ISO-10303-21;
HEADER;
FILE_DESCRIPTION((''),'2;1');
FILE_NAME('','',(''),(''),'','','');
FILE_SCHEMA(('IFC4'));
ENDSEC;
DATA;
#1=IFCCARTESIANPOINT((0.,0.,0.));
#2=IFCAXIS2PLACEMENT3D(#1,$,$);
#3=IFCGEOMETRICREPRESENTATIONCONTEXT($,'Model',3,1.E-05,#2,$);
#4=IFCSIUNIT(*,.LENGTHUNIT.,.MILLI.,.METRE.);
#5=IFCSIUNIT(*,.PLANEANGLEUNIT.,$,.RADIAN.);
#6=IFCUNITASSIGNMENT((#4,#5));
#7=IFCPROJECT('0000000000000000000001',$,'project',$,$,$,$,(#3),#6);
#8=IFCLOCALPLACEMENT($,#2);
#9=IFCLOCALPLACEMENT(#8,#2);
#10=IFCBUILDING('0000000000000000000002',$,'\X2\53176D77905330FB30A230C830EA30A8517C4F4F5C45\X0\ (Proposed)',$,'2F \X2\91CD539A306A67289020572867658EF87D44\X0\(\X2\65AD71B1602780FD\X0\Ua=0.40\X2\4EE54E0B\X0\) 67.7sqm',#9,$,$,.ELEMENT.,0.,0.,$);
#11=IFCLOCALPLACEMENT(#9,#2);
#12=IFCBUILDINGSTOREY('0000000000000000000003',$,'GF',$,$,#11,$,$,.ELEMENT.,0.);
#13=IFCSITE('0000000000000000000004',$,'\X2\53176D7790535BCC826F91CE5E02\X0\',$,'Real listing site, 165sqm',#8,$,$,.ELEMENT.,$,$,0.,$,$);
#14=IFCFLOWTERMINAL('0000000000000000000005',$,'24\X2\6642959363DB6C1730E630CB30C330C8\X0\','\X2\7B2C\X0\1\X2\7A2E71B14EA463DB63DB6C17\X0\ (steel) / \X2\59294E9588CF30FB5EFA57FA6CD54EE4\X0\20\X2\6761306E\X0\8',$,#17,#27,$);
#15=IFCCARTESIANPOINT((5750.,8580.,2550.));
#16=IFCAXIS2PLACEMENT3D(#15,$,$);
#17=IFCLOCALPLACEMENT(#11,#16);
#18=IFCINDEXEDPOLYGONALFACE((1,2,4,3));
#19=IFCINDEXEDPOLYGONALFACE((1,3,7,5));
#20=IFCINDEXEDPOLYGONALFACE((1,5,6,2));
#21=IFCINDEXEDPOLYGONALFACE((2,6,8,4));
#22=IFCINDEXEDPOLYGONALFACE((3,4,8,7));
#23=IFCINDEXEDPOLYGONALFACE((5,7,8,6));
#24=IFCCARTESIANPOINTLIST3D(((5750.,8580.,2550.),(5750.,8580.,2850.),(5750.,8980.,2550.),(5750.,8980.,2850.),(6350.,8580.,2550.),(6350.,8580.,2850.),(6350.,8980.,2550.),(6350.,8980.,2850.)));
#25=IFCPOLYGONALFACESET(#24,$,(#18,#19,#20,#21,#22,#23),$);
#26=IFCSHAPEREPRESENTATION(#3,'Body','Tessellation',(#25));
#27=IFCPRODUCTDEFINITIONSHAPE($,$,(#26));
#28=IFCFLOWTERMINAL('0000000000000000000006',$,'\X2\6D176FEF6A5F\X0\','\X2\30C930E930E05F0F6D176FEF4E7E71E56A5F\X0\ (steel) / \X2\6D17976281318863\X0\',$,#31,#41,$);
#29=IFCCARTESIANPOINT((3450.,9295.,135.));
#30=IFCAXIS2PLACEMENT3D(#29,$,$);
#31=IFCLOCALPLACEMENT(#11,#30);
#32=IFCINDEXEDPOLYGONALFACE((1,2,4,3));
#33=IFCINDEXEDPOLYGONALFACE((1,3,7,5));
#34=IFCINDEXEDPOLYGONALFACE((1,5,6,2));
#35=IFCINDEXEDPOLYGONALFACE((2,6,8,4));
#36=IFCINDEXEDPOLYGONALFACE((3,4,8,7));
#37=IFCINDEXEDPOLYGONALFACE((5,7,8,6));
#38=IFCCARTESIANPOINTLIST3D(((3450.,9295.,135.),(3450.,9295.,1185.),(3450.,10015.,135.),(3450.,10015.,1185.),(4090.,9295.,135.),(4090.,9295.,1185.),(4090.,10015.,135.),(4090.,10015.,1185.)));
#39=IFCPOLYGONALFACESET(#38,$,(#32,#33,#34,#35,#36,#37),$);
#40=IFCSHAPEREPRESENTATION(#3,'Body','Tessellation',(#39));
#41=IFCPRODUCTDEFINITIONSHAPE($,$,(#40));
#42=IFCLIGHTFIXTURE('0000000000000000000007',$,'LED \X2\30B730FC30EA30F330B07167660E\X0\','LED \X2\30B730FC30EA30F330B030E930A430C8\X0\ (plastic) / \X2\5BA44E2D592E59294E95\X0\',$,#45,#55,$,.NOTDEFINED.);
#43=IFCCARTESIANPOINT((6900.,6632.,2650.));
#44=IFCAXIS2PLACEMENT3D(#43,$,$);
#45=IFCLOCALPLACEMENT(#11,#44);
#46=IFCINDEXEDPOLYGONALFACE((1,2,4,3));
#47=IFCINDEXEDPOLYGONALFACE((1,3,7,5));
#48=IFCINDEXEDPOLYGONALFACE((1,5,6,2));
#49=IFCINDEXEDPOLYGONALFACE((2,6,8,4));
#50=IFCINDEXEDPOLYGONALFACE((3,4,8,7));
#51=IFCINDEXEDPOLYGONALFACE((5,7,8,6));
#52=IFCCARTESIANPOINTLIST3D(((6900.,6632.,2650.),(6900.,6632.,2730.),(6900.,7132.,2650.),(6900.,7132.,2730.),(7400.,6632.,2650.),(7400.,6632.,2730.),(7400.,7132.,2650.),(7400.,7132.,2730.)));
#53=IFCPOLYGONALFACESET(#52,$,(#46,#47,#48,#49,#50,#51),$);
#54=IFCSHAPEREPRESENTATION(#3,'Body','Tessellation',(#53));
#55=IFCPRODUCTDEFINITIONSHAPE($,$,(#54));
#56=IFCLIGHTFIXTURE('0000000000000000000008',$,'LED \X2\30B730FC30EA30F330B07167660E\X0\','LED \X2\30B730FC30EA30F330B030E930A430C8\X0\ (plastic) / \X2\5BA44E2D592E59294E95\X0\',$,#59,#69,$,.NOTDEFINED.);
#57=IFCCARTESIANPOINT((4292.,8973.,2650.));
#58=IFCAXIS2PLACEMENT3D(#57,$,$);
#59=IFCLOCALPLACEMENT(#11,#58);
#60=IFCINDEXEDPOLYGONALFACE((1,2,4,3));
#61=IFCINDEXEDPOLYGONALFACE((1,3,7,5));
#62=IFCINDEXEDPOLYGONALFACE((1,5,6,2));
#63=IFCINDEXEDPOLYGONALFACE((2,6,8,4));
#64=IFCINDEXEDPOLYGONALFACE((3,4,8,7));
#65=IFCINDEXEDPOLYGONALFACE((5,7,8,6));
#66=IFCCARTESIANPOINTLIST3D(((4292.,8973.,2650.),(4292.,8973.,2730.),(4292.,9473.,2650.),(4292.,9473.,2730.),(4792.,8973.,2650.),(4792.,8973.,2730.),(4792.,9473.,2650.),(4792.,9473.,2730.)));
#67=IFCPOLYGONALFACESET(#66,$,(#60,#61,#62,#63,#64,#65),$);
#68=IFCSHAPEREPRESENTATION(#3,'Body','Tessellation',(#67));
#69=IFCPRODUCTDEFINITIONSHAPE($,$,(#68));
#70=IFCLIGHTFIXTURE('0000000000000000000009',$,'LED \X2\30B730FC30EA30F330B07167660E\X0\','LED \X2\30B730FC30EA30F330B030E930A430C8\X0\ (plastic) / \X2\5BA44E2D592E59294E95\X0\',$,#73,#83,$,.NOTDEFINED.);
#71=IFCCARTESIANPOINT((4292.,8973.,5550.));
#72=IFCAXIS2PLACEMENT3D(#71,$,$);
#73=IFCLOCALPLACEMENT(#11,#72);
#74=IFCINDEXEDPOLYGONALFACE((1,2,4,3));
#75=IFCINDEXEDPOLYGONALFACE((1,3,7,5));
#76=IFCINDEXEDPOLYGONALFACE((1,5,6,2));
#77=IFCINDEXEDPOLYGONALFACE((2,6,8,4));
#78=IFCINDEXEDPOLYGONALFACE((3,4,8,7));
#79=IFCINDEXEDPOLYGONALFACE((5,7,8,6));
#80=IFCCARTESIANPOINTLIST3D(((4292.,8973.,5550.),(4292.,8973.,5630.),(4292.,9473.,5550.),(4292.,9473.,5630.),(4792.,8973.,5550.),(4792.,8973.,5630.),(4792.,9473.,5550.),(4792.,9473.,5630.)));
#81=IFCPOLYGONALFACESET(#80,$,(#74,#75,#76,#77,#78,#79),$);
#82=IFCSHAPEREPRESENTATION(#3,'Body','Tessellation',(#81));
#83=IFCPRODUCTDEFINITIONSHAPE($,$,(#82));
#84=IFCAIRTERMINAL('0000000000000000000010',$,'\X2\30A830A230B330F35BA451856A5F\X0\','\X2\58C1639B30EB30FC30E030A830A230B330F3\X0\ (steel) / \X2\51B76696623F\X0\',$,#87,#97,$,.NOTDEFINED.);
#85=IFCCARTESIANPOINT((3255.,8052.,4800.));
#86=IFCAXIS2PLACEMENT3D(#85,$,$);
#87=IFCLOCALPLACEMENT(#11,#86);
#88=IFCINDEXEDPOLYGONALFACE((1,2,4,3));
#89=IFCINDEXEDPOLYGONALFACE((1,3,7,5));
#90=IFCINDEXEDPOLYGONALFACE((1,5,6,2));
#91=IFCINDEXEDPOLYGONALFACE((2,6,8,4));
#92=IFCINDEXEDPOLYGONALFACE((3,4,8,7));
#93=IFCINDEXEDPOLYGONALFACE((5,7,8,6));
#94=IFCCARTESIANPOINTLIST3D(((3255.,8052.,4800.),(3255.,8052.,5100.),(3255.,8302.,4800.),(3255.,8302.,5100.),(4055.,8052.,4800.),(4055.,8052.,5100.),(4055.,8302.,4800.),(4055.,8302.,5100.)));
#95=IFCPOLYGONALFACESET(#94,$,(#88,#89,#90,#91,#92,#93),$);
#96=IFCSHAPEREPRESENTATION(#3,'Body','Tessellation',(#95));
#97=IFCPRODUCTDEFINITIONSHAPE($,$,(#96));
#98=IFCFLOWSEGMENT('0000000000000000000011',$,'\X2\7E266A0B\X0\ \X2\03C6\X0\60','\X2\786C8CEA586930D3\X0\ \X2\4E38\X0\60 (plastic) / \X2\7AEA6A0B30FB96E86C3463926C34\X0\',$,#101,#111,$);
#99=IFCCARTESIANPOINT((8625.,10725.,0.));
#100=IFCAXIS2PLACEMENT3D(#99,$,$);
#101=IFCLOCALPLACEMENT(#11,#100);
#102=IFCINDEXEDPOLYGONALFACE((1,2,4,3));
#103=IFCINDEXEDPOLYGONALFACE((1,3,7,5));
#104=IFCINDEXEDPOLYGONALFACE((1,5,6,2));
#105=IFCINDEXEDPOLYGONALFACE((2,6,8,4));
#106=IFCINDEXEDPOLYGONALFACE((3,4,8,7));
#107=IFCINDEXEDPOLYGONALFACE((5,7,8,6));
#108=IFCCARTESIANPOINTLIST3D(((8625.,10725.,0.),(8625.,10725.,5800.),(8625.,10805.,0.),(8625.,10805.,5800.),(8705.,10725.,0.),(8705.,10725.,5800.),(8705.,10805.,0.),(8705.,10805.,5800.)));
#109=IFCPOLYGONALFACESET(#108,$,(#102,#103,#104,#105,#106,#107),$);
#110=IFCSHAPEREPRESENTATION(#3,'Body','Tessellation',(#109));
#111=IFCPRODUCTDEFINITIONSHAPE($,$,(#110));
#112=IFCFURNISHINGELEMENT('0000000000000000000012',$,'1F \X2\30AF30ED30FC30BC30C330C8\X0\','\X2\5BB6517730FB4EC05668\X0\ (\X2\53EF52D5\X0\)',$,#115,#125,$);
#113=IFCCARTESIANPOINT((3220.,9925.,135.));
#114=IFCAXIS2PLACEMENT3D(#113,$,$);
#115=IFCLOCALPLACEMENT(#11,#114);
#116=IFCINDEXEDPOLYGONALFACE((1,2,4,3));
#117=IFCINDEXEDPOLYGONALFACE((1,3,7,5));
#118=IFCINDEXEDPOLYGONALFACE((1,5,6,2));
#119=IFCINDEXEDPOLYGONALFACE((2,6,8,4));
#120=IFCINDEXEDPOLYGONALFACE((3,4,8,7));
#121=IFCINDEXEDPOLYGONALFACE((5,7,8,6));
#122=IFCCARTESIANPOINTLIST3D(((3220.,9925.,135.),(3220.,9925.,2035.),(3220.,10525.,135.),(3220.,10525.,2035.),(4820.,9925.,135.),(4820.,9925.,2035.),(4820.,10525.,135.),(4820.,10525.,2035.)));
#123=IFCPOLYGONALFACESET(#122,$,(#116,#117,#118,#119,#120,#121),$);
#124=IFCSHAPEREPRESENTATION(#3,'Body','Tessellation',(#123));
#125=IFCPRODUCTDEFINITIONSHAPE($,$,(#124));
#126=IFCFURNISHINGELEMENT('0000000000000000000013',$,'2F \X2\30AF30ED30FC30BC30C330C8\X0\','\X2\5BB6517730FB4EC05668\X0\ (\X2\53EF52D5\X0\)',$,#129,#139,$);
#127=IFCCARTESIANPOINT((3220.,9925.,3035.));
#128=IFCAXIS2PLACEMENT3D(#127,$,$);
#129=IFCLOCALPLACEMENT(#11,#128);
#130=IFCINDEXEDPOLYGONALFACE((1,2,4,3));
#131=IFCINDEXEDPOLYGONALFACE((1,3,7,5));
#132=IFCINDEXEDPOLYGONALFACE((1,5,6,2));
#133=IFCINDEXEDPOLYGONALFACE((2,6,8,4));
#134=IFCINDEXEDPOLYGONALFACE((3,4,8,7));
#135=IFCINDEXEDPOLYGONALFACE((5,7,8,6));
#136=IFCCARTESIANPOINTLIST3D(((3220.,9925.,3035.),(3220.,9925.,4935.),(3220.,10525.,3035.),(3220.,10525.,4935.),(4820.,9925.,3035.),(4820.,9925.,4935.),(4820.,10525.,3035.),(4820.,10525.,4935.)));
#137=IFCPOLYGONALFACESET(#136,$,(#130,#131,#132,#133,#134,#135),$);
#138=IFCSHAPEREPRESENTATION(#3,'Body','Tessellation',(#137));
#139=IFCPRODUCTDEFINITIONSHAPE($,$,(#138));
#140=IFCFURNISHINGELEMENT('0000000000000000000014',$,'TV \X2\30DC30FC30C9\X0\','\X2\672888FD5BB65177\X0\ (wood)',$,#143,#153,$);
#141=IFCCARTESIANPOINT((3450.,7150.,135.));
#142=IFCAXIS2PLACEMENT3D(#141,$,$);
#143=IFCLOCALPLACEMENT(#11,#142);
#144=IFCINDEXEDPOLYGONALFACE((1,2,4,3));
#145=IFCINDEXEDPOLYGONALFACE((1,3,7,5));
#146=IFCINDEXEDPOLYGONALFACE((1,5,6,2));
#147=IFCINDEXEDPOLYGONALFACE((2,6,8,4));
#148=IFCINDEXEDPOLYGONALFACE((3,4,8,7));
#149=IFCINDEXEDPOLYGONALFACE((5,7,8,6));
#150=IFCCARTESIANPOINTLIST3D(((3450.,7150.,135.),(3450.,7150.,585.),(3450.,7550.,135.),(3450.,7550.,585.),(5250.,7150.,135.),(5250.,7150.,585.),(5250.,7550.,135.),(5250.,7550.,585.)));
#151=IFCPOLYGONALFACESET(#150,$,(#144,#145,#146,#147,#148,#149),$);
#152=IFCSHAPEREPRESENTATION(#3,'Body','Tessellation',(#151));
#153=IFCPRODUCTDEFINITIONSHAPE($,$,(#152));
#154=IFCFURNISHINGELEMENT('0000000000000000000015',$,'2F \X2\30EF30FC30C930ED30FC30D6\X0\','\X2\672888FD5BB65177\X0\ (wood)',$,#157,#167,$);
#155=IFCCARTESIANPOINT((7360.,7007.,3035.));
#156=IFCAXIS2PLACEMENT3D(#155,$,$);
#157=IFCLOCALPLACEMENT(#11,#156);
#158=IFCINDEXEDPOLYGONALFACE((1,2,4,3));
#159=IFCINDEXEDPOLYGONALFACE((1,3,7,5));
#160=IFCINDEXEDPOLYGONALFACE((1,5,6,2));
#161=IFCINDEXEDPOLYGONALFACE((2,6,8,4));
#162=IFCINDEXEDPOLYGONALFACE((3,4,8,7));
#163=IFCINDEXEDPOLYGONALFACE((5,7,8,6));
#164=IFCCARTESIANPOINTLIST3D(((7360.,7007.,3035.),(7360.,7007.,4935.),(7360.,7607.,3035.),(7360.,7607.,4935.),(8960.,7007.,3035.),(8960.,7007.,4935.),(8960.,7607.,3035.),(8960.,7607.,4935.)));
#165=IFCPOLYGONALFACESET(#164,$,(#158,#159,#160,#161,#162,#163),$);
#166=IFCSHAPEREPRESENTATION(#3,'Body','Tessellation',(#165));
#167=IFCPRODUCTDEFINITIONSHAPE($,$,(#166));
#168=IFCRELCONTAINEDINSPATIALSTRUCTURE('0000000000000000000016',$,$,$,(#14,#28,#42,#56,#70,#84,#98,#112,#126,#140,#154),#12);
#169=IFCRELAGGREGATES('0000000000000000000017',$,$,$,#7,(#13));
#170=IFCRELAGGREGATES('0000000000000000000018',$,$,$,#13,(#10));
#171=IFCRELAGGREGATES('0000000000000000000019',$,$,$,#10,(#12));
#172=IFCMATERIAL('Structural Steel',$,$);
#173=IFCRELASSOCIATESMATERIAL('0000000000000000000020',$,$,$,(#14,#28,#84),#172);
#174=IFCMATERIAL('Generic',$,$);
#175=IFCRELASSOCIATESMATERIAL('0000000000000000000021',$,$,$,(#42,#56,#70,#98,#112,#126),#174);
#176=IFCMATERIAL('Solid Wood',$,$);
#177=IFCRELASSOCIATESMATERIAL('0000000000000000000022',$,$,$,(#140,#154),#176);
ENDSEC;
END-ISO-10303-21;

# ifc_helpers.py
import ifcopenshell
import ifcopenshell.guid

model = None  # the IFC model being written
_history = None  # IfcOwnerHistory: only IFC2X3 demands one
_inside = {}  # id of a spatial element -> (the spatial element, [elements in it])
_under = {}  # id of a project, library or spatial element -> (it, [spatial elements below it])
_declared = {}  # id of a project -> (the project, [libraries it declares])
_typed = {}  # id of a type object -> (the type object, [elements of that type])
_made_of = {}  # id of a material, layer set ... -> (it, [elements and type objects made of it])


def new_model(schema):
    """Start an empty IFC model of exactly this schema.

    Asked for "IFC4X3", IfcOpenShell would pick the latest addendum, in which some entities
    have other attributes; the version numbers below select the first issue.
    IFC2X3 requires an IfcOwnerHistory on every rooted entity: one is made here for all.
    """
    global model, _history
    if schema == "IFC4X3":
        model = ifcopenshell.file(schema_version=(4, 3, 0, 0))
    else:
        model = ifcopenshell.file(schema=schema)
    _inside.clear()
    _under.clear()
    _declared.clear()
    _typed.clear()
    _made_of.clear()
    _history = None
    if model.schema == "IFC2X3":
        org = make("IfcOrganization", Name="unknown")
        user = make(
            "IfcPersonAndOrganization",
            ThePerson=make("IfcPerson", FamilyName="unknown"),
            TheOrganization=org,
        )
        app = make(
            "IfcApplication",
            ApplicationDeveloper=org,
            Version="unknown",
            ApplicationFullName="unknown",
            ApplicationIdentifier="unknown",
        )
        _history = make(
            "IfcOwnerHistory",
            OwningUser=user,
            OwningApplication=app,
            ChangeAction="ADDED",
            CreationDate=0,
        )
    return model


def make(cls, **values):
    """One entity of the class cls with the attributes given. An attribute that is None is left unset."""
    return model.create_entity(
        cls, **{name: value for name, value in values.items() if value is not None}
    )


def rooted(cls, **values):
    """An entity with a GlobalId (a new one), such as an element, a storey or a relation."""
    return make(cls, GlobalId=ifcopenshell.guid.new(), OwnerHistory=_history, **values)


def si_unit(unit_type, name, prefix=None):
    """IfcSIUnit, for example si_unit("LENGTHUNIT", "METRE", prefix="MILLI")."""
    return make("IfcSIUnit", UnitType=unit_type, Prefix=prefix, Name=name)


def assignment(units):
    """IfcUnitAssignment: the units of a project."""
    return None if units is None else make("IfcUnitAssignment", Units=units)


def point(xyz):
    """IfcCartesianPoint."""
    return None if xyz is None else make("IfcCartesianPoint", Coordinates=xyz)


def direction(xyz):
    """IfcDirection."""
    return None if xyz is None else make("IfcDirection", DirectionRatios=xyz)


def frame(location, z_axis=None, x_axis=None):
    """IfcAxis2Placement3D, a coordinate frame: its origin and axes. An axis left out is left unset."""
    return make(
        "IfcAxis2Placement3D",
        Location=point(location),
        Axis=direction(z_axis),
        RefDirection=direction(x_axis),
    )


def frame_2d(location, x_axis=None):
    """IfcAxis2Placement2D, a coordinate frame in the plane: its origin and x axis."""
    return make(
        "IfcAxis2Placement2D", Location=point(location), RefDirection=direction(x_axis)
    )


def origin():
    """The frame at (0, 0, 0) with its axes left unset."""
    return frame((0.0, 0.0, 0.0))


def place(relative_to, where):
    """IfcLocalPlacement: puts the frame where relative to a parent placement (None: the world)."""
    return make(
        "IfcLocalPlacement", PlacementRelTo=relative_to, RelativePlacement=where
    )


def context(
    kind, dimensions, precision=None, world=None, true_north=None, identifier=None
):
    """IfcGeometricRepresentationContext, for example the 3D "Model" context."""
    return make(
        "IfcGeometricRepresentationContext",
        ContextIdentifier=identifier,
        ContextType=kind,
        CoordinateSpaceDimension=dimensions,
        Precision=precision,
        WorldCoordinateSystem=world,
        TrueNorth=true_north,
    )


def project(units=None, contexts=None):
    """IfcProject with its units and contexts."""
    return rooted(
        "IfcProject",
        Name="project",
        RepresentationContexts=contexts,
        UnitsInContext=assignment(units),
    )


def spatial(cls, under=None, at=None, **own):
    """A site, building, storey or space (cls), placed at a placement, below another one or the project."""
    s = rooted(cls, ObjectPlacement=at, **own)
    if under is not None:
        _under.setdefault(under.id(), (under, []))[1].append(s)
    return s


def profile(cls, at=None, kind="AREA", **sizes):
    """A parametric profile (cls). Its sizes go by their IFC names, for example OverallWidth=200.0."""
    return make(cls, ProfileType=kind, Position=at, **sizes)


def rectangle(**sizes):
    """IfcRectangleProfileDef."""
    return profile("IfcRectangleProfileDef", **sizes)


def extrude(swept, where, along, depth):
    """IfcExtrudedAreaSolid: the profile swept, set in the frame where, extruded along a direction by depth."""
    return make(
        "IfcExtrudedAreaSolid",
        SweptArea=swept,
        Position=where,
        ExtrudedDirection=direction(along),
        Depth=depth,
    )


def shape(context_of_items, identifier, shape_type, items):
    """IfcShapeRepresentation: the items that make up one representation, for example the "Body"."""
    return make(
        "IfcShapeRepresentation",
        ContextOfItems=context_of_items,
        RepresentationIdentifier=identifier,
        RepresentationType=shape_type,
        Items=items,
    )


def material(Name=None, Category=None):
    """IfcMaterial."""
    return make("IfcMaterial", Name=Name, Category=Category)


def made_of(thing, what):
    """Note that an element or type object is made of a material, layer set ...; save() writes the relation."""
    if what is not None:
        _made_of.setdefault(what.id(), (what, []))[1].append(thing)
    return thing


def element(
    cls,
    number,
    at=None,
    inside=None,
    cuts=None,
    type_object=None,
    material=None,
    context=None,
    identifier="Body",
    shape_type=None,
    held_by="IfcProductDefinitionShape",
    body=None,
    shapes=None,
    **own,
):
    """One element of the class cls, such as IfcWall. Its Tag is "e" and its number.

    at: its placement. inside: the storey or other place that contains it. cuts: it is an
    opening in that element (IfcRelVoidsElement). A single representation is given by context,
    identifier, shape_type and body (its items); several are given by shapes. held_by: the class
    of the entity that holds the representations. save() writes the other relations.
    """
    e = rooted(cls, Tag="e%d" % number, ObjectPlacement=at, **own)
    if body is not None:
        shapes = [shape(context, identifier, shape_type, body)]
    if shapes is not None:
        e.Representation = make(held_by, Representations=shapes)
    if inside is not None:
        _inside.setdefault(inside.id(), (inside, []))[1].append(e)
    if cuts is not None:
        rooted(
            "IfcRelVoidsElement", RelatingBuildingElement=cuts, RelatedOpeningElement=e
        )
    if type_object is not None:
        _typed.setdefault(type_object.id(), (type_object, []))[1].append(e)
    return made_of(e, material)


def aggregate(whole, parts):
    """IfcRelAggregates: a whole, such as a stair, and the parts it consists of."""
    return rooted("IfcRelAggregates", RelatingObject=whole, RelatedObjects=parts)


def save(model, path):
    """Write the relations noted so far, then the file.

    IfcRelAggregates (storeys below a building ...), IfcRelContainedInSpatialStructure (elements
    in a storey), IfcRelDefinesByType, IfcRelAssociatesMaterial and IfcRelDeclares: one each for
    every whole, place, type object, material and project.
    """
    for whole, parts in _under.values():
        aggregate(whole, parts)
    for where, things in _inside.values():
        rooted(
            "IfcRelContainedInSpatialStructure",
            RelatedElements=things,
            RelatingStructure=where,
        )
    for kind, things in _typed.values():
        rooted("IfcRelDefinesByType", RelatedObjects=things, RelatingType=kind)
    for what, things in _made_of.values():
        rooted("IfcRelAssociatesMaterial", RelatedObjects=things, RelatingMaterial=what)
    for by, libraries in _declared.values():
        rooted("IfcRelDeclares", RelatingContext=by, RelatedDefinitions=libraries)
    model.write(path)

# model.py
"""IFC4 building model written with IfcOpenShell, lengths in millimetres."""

from ifc_helpers import new_model, si_unit, frame, frame_2d, origin, place, context, project, spatial, rectangle, extrude, material, element, save


model = new_model("IFC4")

# Units and contexts
model_context = context("Model", 3, precision=1e-05, world=origin())
ifc_project = project(units=[si_unit("LENGTHUNIT", "METRE", prefix="MILLI"), si_unit("PLANEANGLEUNIT", "RADIAN")], contexts=[model_context])

# Site, building, storey
site_placement = place(None, origin())
site = spatial("IfcSite", under=ifc_project, at=site_placement, Name="北海道富良野市", ObjectType="Real listing site, 165sqm", CompositionType="ELEMENT", RefElevation=0.0)
building_placement = place(site_placement, origin())
building = spatial("IfcBuilding", under=site, at=building_placement, Name="北海道・アトリエ兼住居 (Proposed)", ObjectType="2F 重厚な木造在来軸組(断熱性能Ua=0.40以下) 67.7sqm", CompositionType="ELEMENT", ElevationOfRefHeight=0.0, ElevationOfTerrain=0.0)
storey_placement = place(building_placement, origin())
storey = spatial("IfcBuildingStorey", under=building, at=storey_placement, Name="GF", CompositionType="ELEMENT", Elevation=0.0)

# Shared definitions
ifc_material_1 = material(Name="Solid Wood")

# Shared definitions
ifc_material_2 = material(Name="Generic")

# Flow terminals
ifc_material_3 = material(Name="Structural Steel")
flow_terminal_1_placement = place(storey_placement, frame((5750.0, 8580.0, 2550.0)))
element("IfcFlowTerminal", 1, at=flow_terminal_1_placement, inside=storey, material=ifc_material_3, Name="24時間換気ユニット", Description="第1種熱交換換気 (steel) / 天井裏・建基法令20条の8", context=model_context, shape_type="SweptSolid", body=[
    extrude(rectangle(XDim=600.0, YDim=400.0, at=frame_2d((300.0, 200.0))), frame((5750.0, 8580.0, 2550.0)), (0.0, 0.0, 1.0), 300.0),
])
flow_terminal_2_placement = place(storey_placement, frame((3450.0, 9295.0, 135.0)))
element("IfcFlowTerminal", 2, at=flow_terminal_2_placement, inside=storey, material=ifc_material_3, Name="洗濯機", Description="ドラム式洗濯乾燥機 (steel) / 洗面脱衣", context=model_context, shape_type="SweptSolid", body=[
    extrude(rectangle(XDim=640.0, YDim=720.0, at=frame_2d((320.0, 360.0))), frame((3450.0, 9295.0, 135.0)), (0.0, 0.0, 1.0), 1050.0),
])

# Light fixtures
light_fixture_1_placement = place(storey_placement, frame((6900.0, 6632.0, 2650.0)))
element("IfcLightFixture", 3, at=light_fixture_1_placement, inside=storey, material=ifc_material_2, Name="LED シーリング照明", Description="LED シーリングライト (plastic) / 室中央天井", PredefinedType="NOTDEFINED", context=model_context, shape_type="SweptSolid", body=[
    extrude(rectangle(XDim=500.0, YDim=500.0, at=frame_2d((250.0, 250.0))), frame((6900.0, 6632.0, 2650.0)), (0.0, 0.0, 1.0), 80.0),
])
light_fixture_2_placement = place(storey_placement, frame((4292.0, 8973.0, 2650.0)))
element("IfcLightFixture", 4, at=light_fixture_2_placement, inside=storey, material=ifc_material_2, Name="LED シーリング照明", Description="LED シーリングライト (plastic) / 室中央天井", PredefinedType="NOTDEFINED", context=model_context, shape_type="SweptSolid", body=[
    extrude(rectangle(XDim=500.0, YDim=500.0, at=frame_2d((250.0, 250.0))), frame((4292.0, 8973.0, 2650.0)), (0.0, 0.0, 1.0), 80.0),
])
light_fixture_3_placement = place(storey_placement, frame((4292.0, 8973.0, 5550.0)))
element("IfcLightFixture", 5, at=light_fixture_3_placement, inside=storey, material=ifc_material_2, Name="LED シーリング照明", Description="LED シーリングライト (plastic) / 室中央天井", PredefinedType="NOTDEFINED", context=model_context, shape_type="SweptSolid", body=[
    extrude(rectangle(XDim=500.0, YDim=500.0, at=frame_2d((250.0, 250.0))), frame((4292.0, 8973.0, 5550.0)), (0.0, 0.0, 1.0), 80.0),
])

# Air terminal
air_terminal_placement = place(storey_placement, frame((3255.0, 8052.0, 4800.0)))
element("IfcAirTerminal", 6, at=air_terminal_placement, inside=storey, material=ifc_material_3, Name="エアコン室内機", Description="壁掛ルームエアコン (steel) / 冷暖房", PredefinedType="NOTDEFINED", context=model_context, shape_type="SweptSolid", body=[
    extrude(rectangle(XDim=800.0, YDim=250.0, at=frame_2d((400.0, 125.0))), frame((3255.0, 8052.0, 4800.0)), (0.0, 0.0, 1.0), 300.0),
])

# Flow segment
flow_segment_placement = place(storey_placement, frame((8625.0, 10725.0, 0.0)))
element("IfcFlowSegment", 7, at=flow_segment_placement, inside=storey, material=ifc_material_2, Name="縦樋 φ60", Description="硬質塩ビ 丸60 (plastic) / 竪樋・雨水排水", context=model_context, shape_type="SweptSolid", body=[
    extrude(rectangle(XDim=80.0, YDim=80.0, at=frame_2d((40.0, 40.0))), frame((8625.0, 10725.0, 0.0)), (0.0, 0.0, 1.0), 5800.0),
])

# Furnishing elements
furnishing_1_placement = place(storey_placement, frame((3220.0, 9925.0, 135.0)))
element("IfcFurnishingElement", 8, at=furnishing_1_placement, inside=storey, material=ifc_material_2, Name="1F クローゼット", Description="家具・什器 (可動)", context=model_context, shape_type="SweptSolid", body=[
    extrude(rectangle(XDim=1600.0, YDim=600.0, at=frame_2d((800.0, 300.0))), frame((3220.0, 9925.0, 135.0)), (0.0, 0.0, 1.0), 1900.0),
])
furnishing_2_placement = place(storey_placement, frame((3220.0, 9925.0, 3035.0)))
element("IfcFurnishingElement", 9, at=furnishing_2_placement, inside=storey, material=ifc_material_2, Name="2F クローゼット", Description="家具・什器 (可動)", context=model_context, shape_type="SweptSolid", body=[
    extrude(rectangle(XDim=1600.0, YDim=600.0, at=frame_2d((800.0, 300.0))), frame((3220.0, 9925.0, 3035.0)), (0.0, 0.0, 1.0), 1900.0),
])
furnishing_3_placement = place(storey_placement, frame((3450.0, 7150.0, 135.0)))
element("IfcFurnishingElement", 10, at=furnishing_3_placement, inside=storey, material=ifc_material_1, Name="TV ボード", Description="木製家具 (wood)", context=model_context, shape_type="SweptSolid", body=[
    extrude(rectangle(XDim=1800.0, YDim=400.0, at=frame_2d((900.0, 200.0))), frame((3450.0, 7150.0, 135.0)), (0.0, 0.0, 1.0), 450.0),
])
furnishing_4_placement = place(storey_placement, frame((7360.0, 7007.0, 3035.0)))
element("IfcFurnishingElement", 11, at=furnishing_4_placement, inside=storey, material=ifc_material_1, Name="2F ワードローブ", Description="木製家具 (wood)", context=model_context, shape_type="SweptSolid", body=[
    extrude(rectangle(XDim=1600.0, YDim=600.0, at=frame_2d((800.0, 300.0))), frame((7360.0, 7007.0, 3035.0)), (0.0, 0.0, 1.0), 1900.0),
])

save(model, "model.ifc")
